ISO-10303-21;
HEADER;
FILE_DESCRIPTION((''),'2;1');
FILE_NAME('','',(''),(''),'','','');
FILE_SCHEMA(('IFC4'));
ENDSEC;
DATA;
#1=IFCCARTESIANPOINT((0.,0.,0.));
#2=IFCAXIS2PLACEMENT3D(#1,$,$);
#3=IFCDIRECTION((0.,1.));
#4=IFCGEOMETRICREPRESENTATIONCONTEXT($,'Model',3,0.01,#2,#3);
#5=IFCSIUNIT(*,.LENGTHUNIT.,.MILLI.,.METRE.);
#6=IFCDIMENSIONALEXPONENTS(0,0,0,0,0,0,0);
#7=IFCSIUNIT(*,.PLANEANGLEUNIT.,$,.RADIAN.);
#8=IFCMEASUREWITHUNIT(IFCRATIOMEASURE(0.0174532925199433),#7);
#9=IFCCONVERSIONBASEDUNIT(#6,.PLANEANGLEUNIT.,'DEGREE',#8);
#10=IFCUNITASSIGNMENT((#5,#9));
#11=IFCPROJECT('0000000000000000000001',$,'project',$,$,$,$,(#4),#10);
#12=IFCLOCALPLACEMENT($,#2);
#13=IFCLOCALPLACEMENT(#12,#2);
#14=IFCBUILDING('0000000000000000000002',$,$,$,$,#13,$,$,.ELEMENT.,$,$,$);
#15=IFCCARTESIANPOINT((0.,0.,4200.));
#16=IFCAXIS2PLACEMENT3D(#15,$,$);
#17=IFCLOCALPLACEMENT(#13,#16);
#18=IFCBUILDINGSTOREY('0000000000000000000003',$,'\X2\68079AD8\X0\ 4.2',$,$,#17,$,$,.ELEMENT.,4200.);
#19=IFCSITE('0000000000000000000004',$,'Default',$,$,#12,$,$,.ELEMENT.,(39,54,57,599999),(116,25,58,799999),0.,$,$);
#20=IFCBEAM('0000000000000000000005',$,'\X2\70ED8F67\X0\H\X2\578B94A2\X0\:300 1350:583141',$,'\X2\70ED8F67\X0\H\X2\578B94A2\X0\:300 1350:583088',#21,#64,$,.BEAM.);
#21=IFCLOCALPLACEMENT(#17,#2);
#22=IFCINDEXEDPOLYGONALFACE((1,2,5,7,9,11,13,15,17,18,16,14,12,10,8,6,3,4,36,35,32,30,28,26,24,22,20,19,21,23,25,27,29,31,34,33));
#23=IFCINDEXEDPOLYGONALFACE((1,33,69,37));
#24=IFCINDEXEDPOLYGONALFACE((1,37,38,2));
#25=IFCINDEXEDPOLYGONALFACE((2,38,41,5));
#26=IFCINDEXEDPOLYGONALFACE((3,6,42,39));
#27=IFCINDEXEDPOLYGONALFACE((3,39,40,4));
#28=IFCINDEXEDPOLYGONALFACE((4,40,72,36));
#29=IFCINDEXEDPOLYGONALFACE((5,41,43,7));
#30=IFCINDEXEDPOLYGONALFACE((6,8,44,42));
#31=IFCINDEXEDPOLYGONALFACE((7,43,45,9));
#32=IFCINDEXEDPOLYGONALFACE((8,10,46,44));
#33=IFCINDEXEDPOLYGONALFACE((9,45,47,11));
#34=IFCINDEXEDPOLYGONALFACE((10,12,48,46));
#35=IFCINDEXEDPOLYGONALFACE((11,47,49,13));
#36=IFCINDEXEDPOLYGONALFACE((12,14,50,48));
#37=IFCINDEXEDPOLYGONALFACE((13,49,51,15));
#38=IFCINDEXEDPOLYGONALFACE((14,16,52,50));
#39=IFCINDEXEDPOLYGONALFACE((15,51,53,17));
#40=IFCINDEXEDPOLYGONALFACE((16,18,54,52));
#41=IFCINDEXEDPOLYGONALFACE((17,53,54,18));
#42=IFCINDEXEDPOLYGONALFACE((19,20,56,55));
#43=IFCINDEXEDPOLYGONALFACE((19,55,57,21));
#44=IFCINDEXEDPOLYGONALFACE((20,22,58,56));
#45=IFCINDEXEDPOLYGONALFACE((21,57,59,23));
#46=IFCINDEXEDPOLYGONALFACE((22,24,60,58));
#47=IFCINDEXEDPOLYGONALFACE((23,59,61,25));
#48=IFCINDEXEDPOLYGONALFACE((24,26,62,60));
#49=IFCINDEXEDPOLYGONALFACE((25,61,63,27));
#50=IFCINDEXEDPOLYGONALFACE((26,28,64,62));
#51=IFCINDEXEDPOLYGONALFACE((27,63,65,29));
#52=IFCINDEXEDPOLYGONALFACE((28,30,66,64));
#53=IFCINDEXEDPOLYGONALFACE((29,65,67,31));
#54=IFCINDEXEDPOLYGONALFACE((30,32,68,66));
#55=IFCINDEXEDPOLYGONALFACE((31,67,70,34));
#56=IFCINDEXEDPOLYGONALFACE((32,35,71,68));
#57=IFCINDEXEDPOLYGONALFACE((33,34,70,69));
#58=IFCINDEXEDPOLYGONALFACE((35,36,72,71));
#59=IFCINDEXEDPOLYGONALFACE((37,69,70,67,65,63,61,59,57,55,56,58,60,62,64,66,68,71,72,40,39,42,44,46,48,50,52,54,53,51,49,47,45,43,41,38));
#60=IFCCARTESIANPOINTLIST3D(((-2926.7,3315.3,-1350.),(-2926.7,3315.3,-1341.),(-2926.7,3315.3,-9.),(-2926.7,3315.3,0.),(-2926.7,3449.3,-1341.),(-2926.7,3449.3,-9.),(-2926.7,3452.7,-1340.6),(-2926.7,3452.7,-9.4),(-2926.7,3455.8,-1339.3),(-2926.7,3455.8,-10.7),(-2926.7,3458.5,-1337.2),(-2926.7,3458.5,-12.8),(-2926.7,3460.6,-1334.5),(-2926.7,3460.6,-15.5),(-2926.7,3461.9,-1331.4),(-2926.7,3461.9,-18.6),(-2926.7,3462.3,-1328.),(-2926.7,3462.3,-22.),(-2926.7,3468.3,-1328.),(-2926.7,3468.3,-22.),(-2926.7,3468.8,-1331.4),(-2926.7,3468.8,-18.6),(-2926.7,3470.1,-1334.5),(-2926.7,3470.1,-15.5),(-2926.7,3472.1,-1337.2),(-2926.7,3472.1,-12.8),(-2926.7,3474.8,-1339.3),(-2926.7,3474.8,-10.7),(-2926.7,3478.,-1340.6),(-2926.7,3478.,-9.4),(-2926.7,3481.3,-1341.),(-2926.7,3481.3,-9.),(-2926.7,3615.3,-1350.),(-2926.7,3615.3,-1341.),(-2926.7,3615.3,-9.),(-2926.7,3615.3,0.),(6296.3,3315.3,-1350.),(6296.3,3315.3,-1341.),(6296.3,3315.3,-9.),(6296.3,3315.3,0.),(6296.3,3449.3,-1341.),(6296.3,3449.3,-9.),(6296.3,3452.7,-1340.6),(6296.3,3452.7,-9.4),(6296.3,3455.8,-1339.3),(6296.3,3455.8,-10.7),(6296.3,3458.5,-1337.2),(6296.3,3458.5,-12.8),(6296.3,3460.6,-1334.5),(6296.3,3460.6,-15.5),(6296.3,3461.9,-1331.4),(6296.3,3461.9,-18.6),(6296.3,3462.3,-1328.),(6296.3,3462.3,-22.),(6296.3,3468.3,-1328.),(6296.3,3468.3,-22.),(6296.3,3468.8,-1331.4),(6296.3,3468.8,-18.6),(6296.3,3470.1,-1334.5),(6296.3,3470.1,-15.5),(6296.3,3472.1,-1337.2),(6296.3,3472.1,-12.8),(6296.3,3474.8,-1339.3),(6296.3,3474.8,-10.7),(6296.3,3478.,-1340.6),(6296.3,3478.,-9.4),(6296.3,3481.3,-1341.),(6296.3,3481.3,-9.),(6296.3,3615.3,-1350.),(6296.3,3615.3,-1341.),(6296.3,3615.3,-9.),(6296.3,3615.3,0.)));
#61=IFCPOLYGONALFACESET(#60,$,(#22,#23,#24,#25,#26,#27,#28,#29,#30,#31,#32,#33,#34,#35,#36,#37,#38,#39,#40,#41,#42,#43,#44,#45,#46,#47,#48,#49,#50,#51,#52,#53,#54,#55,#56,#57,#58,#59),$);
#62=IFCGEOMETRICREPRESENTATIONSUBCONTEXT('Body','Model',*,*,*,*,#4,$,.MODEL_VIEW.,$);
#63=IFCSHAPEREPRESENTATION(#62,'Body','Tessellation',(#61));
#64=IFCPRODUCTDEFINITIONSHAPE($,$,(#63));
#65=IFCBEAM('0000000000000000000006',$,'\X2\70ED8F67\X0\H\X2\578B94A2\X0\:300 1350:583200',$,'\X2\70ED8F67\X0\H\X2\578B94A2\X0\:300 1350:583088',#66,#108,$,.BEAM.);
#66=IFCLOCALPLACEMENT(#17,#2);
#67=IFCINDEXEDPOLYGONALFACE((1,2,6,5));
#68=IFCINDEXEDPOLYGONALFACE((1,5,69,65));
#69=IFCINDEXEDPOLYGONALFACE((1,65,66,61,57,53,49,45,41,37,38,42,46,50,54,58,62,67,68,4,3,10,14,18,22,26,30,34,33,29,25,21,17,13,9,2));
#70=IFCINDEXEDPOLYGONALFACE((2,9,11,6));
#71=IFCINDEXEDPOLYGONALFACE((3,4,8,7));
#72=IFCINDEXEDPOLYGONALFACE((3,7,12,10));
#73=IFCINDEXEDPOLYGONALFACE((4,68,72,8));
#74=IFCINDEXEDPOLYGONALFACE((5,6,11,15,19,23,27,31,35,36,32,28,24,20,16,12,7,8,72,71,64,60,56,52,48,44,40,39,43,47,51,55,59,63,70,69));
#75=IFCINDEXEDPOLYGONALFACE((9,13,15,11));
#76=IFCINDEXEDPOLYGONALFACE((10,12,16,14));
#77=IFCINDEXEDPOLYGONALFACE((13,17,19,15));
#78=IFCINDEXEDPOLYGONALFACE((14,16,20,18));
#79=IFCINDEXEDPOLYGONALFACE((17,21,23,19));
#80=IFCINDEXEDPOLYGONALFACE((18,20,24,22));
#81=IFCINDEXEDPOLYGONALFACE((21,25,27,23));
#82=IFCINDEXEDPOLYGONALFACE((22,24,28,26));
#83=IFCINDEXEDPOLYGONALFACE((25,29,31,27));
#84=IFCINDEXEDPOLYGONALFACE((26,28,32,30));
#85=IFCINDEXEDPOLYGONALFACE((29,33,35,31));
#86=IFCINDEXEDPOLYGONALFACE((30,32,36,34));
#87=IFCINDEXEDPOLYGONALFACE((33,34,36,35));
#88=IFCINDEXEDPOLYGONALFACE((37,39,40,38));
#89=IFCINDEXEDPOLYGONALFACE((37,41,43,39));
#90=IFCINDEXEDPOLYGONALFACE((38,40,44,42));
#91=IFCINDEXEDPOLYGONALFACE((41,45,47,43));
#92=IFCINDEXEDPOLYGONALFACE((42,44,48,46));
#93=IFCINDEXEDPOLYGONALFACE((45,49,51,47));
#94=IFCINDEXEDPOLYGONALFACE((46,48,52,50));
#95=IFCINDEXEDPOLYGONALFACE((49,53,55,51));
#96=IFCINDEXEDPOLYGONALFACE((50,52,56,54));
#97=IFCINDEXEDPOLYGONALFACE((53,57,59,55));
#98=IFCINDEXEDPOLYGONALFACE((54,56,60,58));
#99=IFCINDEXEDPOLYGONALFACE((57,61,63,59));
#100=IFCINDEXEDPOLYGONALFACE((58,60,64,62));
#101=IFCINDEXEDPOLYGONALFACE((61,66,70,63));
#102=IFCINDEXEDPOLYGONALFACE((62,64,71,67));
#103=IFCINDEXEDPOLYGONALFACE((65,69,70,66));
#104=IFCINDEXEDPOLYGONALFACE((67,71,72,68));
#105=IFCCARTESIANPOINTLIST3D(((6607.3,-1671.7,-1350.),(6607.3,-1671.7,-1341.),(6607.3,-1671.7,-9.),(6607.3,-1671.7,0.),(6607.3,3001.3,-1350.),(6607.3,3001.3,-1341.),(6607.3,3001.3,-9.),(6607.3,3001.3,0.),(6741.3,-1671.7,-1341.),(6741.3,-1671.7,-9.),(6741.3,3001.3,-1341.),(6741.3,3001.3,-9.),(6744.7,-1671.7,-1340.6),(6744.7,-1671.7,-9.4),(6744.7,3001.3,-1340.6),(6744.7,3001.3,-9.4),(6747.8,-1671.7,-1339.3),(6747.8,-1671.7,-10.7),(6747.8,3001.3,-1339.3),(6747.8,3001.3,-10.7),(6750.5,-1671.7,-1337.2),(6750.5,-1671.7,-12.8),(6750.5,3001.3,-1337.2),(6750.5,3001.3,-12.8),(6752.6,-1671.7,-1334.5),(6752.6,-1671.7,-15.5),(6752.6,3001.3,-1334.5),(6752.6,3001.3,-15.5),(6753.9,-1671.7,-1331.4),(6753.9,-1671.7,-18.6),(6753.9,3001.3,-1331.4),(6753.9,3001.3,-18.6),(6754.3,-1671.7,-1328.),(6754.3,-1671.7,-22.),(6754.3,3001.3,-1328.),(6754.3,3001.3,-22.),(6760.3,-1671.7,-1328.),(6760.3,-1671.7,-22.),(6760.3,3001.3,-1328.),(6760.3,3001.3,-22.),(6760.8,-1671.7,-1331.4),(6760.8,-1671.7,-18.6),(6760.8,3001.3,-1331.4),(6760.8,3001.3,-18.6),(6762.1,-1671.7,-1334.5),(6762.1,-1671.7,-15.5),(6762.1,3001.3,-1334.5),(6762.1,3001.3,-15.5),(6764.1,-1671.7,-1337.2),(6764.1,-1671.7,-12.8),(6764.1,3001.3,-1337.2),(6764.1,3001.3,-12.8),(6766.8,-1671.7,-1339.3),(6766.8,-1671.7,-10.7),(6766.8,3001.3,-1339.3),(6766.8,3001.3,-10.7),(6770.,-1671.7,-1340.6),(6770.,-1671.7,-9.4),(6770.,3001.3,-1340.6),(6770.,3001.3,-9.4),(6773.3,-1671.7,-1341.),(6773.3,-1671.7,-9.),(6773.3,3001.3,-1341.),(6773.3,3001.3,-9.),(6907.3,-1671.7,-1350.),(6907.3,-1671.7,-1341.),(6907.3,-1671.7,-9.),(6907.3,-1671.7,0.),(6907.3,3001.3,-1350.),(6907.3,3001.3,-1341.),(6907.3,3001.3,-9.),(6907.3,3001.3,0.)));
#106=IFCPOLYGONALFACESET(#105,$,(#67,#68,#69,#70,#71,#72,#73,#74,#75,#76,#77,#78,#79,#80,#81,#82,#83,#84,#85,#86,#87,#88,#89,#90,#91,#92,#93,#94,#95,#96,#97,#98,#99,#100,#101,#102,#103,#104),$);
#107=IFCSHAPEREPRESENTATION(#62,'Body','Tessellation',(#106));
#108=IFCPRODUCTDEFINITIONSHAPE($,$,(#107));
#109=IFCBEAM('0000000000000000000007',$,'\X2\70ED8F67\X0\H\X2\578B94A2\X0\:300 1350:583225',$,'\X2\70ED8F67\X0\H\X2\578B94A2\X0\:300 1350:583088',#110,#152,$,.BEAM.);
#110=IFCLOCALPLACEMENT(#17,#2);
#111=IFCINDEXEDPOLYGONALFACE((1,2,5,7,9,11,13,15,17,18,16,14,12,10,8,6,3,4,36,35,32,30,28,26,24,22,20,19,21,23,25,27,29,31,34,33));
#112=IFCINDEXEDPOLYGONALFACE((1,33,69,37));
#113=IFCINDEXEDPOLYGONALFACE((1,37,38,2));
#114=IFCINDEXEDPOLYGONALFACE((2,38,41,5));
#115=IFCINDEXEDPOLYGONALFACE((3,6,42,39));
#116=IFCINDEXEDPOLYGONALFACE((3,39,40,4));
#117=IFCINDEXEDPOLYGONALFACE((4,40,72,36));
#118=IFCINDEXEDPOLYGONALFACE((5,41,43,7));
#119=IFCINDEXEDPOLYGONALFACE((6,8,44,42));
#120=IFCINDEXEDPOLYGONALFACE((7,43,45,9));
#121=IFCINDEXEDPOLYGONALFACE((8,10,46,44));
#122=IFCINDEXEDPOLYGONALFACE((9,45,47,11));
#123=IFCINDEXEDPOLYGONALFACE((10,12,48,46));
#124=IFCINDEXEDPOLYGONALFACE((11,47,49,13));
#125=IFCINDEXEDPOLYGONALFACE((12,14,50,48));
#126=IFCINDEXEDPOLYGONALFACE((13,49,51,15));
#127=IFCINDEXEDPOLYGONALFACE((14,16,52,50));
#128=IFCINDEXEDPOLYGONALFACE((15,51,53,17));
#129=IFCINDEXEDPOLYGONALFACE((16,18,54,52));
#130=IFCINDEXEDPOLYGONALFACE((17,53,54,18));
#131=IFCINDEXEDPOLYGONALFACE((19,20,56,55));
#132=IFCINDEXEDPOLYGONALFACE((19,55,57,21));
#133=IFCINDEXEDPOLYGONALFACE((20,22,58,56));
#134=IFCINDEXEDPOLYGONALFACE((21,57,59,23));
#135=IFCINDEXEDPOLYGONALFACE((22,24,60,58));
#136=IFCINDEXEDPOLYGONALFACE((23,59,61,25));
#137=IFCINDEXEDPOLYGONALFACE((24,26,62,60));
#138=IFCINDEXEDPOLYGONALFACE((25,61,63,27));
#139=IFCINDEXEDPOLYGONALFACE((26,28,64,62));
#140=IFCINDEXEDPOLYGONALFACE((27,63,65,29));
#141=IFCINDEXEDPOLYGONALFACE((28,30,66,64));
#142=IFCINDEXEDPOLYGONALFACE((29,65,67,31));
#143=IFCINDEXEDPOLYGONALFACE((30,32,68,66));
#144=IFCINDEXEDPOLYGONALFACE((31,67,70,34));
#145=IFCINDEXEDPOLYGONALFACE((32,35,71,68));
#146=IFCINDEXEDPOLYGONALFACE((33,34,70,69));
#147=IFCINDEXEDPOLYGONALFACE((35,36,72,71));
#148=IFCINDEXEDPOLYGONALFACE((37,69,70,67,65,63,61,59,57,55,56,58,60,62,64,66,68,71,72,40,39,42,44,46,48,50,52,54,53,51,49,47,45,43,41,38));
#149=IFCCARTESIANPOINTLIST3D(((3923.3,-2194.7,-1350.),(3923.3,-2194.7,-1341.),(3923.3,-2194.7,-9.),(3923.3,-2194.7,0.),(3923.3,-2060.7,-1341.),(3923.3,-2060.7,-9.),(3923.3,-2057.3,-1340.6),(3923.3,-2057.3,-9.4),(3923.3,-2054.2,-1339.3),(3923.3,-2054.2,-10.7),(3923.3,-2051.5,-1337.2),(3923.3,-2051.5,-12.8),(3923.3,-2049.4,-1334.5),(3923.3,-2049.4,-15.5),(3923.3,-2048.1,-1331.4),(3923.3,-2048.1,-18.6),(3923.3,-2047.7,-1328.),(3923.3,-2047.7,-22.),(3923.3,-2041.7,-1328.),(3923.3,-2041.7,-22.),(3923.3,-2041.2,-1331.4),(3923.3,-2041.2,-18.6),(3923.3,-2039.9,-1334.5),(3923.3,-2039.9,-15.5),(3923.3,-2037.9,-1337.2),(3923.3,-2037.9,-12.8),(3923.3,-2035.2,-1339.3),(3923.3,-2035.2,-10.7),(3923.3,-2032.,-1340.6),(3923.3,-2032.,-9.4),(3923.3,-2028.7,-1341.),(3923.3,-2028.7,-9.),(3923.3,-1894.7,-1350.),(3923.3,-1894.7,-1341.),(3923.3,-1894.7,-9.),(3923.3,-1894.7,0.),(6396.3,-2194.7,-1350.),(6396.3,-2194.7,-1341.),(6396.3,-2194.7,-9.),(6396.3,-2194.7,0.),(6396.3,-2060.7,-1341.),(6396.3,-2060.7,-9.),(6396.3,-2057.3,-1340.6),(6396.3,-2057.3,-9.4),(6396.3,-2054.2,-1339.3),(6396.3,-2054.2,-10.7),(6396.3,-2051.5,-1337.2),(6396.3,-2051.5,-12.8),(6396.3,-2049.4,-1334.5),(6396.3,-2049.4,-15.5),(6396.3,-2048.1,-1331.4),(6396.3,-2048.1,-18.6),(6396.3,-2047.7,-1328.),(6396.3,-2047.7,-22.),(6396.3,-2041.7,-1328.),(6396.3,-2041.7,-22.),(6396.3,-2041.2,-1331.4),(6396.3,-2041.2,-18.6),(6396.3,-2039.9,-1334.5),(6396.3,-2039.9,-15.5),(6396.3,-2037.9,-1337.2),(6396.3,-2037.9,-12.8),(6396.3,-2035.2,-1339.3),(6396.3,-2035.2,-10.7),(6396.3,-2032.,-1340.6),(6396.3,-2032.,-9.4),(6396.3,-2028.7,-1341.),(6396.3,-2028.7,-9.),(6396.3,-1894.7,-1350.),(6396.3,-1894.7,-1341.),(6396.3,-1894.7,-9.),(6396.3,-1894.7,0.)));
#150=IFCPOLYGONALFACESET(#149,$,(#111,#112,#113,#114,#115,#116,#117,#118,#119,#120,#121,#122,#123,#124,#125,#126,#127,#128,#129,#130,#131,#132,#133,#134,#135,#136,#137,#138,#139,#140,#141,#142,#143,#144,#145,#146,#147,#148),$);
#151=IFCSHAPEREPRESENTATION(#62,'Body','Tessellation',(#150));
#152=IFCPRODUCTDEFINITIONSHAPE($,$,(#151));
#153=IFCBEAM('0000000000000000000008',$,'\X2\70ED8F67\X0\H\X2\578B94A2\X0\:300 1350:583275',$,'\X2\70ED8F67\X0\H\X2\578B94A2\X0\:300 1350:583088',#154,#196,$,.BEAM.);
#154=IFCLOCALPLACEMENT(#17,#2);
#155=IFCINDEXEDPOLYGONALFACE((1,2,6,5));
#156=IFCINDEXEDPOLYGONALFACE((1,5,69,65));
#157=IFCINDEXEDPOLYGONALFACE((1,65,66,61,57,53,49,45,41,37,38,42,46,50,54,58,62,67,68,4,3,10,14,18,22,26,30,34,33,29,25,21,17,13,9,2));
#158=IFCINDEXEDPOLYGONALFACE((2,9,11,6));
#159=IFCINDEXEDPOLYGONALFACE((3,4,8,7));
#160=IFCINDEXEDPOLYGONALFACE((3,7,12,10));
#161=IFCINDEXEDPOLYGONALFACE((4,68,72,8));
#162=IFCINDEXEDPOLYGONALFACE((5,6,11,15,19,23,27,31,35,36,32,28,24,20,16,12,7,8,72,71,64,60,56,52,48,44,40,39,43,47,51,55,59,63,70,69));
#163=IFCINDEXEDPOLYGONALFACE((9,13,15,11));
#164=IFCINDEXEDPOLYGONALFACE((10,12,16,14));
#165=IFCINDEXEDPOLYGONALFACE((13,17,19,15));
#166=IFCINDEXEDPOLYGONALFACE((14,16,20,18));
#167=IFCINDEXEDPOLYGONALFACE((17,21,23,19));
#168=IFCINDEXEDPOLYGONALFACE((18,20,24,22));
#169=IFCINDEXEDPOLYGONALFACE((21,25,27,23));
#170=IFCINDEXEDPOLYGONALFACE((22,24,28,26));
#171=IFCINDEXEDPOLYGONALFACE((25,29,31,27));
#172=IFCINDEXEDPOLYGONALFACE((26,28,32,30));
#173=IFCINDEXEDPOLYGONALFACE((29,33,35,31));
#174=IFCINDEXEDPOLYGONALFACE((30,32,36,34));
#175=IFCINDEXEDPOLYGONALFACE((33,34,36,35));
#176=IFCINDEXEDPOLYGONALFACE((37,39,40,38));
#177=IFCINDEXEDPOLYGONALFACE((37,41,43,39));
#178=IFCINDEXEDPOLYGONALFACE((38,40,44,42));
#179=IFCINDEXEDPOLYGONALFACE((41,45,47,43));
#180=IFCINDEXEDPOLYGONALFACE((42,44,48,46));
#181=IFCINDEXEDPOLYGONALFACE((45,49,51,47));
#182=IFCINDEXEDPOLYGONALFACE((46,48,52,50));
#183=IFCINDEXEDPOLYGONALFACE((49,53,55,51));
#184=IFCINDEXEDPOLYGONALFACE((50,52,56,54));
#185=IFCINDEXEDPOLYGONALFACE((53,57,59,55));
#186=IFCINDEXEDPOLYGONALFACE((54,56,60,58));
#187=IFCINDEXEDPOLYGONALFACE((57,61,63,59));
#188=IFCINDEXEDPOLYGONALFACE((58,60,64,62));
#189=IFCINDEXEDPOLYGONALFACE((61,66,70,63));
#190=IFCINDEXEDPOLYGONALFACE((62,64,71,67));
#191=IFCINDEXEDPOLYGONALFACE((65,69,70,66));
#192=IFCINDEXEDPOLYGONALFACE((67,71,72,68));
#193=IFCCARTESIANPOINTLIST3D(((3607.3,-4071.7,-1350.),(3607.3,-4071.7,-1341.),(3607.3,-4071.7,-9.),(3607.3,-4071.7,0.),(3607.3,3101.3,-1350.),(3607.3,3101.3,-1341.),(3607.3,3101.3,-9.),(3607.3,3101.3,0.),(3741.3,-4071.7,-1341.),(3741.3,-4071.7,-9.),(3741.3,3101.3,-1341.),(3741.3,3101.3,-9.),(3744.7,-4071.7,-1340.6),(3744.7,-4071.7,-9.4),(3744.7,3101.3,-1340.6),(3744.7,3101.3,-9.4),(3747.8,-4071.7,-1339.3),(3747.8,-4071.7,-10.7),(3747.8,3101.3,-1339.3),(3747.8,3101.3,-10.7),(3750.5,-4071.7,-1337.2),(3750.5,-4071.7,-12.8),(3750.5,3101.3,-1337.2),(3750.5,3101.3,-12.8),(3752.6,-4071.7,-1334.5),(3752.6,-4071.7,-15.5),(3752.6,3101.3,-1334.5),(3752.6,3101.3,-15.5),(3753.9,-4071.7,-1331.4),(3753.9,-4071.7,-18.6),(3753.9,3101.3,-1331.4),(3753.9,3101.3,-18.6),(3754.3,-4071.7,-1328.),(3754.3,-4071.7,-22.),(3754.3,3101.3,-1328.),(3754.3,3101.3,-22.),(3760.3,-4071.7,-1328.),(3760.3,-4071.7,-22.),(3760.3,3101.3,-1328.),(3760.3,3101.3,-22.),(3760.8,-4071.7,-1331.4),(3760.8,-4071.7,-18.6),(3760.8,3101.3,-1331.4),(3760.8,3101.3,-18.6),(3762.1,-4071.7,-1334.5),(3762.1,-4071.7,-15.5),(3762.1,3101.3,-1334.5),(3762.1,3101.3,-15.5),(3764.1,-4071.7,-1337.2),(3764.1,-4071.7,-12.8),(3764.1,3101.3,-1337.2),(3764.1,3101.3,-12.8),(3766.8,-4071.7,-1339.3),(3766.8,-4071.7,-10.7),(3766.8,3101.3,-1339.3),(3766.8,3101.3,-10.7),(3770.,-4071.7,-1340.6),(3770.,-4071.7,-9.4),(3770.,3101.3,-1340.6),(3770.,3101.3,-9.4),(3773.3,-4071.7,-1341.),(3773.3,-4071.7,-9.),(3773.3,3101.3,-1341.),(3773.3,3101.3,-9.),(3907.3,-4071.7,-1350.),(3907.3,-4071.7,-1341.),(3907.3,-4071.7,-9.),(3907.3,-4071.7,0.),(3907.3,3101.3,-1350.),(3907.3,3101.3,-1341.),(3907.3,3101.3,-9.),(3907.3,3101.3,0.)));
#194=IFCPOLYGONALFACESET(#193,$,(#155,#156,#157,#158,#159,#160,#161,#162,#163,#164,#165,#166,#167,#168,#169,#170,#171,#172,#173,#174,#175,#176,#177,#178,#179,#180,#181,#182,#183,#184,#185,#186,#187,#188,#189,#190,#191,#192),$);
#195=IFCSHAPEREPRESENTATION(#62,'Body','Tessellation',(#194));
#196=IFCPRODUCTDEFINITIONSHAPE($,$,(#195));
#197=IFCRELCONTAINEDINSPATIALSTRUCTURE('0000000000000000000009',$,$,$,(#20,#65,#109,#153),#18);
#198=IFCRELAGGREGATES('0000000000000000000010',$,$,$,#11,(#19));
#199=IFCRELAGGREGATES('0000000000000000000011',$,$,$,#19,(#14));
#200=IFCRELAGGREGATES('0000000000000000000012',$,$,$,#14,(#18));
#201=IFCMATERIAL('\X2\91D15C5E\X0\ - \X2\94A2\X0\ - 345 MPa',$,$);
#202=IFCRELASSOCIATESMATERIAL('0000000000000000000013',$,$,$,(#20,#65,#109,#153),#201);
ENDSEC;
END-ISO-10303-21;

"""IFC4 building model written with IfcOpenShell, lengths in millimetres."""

from ifc_helpers import new_model, entity, si_unit, converted_unit, direction, frame, frame_2d, origin, place, context, subcontext, project, spatial, i_section, extrude, material, element, save


model = new_model("IFC4")

# Units and contexts
model_context = context("Model", 3, precision=0.01, world=origin(), true_north=direction((0.0, 1.0)))
body_context = subcontext(model_context, "Body", "Model", "MODEL_VIEW")
ifc_project = project(units=[si_unit("LENGTHUNIT", "METRE", prefix="MILLI"), converted_unit("PLANEANGLEUNIT", "DEGREE", entity("IfcRatioMeasure", 0.0174532925199433), si_unit("PLANEANGLEUNIT", "RADIAN"), dimensions=[0, 0, 0, 0, 0, 0, 0])], contexts=[model_context])

# Site, building, storey
site_placement = place(None, origin())
site = spatial("IfcSite", under=ifc_project, at=site_placement, Name="Default", CompositionType="ELEMENT", RefLatitude=(39, 54, 57, 599999), RefLongitude=(116, 25, 58, 799999), RefElevation=0.0)
building_placement = place(site_placement, origin())
building = spatial("IfcBuilding", under=site, at=building_placement, CompositionType="ELEMENT")
storey_placement = place(building_placement, frame((0.0, 0.0, 4200.0)))
storey = spatial("IfcBuildingStorey", under=building, at=storey_placement, Name="标高 4.2", CompositionType="ELEMENT", Elevation=4200.0)

# Beams
ifc_material_1 = material(Name="金属 - 钢 - 345 MPa")
beam_1_placement = place(storey_placement, frame((-2942.7, 3465.3, 0.0)))
element("IfcBeam", 1, at=beam_1_placement, inside=storey, material=ifc_material_1, Name="热轧H型钢:300 1350:583141", ObjectType="热轧H型钢:300 1350:583088", PredefinedType="BEAM", context=body_context, shape_type="SweptSolid", body=[
    extrude(i_section(OverallWidth=300.0, OverallDepth=1350.0, WebThickness=6.0, FlangeThickness=9.0, FilletRadius=13.0, at=frame_2d((0.0, 0.0), x_axis=(0.0, 1.0))), frame((16.0, 0.0, -675.0), z_axis=(1.0, 0.0, 0.0), x_axis=(0.0, 0.0, -1.0)), (0.0, 0.0, 1.0), 9223.0),
])
beam_2_placement = place(storey_placement, frame((6757.3, 3015.3, 0.0), z_axis=(0.0, 0.0, 1.0), x_axis=(0.0, -1.0, 0.0)))
element("IfcBeam", 2, at=beam_2_placement, inside=storey, material=ifc_material_1, Name="热轧H型钢:300 1350:583200", ObjectType="热轧H型钢:300 1350:583088", PredefinedType="BEAM", context=body_context, shape_type="SweptSolid", body=[
    extrude(i_section(OverallWidth=300.0, OverallDepth=1350.0, WebThickness=6.0, FlangeThickness=9.0, FilletRadius=13.0, at=frame_2d((0.0, 0.0), x_axis=(0.0, 1.0))), frame((14.0, 0.0, -675.0), z_axis=(1.0, 0.0, 0.0), x_axis=(0.0, 0.0, -1.0)), (0.0, 0.0, 1.0), 4673.0),
])
beam_3_placement = place(storey_placement, frame((6407.3, -2044.7, 0.0), z_axis=(0.0, 0.0, 1.0), x_axis=(-1.0, 0.0, 0.0)))
element("IfcBeam", 3, at=beam_3_placement, inside=storey, material=ifc_material_1, Name="热轧H型钢:300 1350:583225", ObjectType="热轧H型钢:300 1350:583088", PredefinedType="BEAM", context=body_context, shape_type="SweptSolid", body=[
    extrude(i_section(OverallWidth=300.0, OverallDepth=1350.0, WebThickness=6.0, FlangeThickness=9.0, FilletRadius=13.0, at=frame_2d((0.0, 0.0), x_axis=(0.0, 1.0))), frame((11.0, 0.0, -675.0), z_axis=(1.0, 0.0, 0.0), x_axis=(0.0, 0.0, -1.0)), (0.0, 0.0, 1.0), 2473.0),
])
beam_4_placement = place(storey_placement, frame((3757.3, -4084.7, 0.0), z_axis=(0.0, 0.0, 1.0), x_axis=(0.0, 1.0, 0.0)))
element("IfcBeam", 4, at=beam_4_placement, inside=storey, material=ifc_material_1, Name="热轧H型钢:300 1350:583275", ObjectType="热轧H型钢:300 1350:583088", PredefinedType="BEAM", context=body_context, shape_type="SweptSolid", body=[
    extrude(i_section(OverallWidth=300.0, OverallDepth=1350.0, WebThickness=6.0, FlangeThickness=9.0, FilletRadius=13.0, at=frame_2d((0.0, 0.0), x_axis=(0.0, 1.0))), frame((13.0, 0.0, -675.0), z_axis=(1.0, 0.0, 0.0), x_axis=(0.0, 0.0, -1.0)), (0.0, 0.0, 1.0), 7173.0),
])

save(model, "model.ifc")
